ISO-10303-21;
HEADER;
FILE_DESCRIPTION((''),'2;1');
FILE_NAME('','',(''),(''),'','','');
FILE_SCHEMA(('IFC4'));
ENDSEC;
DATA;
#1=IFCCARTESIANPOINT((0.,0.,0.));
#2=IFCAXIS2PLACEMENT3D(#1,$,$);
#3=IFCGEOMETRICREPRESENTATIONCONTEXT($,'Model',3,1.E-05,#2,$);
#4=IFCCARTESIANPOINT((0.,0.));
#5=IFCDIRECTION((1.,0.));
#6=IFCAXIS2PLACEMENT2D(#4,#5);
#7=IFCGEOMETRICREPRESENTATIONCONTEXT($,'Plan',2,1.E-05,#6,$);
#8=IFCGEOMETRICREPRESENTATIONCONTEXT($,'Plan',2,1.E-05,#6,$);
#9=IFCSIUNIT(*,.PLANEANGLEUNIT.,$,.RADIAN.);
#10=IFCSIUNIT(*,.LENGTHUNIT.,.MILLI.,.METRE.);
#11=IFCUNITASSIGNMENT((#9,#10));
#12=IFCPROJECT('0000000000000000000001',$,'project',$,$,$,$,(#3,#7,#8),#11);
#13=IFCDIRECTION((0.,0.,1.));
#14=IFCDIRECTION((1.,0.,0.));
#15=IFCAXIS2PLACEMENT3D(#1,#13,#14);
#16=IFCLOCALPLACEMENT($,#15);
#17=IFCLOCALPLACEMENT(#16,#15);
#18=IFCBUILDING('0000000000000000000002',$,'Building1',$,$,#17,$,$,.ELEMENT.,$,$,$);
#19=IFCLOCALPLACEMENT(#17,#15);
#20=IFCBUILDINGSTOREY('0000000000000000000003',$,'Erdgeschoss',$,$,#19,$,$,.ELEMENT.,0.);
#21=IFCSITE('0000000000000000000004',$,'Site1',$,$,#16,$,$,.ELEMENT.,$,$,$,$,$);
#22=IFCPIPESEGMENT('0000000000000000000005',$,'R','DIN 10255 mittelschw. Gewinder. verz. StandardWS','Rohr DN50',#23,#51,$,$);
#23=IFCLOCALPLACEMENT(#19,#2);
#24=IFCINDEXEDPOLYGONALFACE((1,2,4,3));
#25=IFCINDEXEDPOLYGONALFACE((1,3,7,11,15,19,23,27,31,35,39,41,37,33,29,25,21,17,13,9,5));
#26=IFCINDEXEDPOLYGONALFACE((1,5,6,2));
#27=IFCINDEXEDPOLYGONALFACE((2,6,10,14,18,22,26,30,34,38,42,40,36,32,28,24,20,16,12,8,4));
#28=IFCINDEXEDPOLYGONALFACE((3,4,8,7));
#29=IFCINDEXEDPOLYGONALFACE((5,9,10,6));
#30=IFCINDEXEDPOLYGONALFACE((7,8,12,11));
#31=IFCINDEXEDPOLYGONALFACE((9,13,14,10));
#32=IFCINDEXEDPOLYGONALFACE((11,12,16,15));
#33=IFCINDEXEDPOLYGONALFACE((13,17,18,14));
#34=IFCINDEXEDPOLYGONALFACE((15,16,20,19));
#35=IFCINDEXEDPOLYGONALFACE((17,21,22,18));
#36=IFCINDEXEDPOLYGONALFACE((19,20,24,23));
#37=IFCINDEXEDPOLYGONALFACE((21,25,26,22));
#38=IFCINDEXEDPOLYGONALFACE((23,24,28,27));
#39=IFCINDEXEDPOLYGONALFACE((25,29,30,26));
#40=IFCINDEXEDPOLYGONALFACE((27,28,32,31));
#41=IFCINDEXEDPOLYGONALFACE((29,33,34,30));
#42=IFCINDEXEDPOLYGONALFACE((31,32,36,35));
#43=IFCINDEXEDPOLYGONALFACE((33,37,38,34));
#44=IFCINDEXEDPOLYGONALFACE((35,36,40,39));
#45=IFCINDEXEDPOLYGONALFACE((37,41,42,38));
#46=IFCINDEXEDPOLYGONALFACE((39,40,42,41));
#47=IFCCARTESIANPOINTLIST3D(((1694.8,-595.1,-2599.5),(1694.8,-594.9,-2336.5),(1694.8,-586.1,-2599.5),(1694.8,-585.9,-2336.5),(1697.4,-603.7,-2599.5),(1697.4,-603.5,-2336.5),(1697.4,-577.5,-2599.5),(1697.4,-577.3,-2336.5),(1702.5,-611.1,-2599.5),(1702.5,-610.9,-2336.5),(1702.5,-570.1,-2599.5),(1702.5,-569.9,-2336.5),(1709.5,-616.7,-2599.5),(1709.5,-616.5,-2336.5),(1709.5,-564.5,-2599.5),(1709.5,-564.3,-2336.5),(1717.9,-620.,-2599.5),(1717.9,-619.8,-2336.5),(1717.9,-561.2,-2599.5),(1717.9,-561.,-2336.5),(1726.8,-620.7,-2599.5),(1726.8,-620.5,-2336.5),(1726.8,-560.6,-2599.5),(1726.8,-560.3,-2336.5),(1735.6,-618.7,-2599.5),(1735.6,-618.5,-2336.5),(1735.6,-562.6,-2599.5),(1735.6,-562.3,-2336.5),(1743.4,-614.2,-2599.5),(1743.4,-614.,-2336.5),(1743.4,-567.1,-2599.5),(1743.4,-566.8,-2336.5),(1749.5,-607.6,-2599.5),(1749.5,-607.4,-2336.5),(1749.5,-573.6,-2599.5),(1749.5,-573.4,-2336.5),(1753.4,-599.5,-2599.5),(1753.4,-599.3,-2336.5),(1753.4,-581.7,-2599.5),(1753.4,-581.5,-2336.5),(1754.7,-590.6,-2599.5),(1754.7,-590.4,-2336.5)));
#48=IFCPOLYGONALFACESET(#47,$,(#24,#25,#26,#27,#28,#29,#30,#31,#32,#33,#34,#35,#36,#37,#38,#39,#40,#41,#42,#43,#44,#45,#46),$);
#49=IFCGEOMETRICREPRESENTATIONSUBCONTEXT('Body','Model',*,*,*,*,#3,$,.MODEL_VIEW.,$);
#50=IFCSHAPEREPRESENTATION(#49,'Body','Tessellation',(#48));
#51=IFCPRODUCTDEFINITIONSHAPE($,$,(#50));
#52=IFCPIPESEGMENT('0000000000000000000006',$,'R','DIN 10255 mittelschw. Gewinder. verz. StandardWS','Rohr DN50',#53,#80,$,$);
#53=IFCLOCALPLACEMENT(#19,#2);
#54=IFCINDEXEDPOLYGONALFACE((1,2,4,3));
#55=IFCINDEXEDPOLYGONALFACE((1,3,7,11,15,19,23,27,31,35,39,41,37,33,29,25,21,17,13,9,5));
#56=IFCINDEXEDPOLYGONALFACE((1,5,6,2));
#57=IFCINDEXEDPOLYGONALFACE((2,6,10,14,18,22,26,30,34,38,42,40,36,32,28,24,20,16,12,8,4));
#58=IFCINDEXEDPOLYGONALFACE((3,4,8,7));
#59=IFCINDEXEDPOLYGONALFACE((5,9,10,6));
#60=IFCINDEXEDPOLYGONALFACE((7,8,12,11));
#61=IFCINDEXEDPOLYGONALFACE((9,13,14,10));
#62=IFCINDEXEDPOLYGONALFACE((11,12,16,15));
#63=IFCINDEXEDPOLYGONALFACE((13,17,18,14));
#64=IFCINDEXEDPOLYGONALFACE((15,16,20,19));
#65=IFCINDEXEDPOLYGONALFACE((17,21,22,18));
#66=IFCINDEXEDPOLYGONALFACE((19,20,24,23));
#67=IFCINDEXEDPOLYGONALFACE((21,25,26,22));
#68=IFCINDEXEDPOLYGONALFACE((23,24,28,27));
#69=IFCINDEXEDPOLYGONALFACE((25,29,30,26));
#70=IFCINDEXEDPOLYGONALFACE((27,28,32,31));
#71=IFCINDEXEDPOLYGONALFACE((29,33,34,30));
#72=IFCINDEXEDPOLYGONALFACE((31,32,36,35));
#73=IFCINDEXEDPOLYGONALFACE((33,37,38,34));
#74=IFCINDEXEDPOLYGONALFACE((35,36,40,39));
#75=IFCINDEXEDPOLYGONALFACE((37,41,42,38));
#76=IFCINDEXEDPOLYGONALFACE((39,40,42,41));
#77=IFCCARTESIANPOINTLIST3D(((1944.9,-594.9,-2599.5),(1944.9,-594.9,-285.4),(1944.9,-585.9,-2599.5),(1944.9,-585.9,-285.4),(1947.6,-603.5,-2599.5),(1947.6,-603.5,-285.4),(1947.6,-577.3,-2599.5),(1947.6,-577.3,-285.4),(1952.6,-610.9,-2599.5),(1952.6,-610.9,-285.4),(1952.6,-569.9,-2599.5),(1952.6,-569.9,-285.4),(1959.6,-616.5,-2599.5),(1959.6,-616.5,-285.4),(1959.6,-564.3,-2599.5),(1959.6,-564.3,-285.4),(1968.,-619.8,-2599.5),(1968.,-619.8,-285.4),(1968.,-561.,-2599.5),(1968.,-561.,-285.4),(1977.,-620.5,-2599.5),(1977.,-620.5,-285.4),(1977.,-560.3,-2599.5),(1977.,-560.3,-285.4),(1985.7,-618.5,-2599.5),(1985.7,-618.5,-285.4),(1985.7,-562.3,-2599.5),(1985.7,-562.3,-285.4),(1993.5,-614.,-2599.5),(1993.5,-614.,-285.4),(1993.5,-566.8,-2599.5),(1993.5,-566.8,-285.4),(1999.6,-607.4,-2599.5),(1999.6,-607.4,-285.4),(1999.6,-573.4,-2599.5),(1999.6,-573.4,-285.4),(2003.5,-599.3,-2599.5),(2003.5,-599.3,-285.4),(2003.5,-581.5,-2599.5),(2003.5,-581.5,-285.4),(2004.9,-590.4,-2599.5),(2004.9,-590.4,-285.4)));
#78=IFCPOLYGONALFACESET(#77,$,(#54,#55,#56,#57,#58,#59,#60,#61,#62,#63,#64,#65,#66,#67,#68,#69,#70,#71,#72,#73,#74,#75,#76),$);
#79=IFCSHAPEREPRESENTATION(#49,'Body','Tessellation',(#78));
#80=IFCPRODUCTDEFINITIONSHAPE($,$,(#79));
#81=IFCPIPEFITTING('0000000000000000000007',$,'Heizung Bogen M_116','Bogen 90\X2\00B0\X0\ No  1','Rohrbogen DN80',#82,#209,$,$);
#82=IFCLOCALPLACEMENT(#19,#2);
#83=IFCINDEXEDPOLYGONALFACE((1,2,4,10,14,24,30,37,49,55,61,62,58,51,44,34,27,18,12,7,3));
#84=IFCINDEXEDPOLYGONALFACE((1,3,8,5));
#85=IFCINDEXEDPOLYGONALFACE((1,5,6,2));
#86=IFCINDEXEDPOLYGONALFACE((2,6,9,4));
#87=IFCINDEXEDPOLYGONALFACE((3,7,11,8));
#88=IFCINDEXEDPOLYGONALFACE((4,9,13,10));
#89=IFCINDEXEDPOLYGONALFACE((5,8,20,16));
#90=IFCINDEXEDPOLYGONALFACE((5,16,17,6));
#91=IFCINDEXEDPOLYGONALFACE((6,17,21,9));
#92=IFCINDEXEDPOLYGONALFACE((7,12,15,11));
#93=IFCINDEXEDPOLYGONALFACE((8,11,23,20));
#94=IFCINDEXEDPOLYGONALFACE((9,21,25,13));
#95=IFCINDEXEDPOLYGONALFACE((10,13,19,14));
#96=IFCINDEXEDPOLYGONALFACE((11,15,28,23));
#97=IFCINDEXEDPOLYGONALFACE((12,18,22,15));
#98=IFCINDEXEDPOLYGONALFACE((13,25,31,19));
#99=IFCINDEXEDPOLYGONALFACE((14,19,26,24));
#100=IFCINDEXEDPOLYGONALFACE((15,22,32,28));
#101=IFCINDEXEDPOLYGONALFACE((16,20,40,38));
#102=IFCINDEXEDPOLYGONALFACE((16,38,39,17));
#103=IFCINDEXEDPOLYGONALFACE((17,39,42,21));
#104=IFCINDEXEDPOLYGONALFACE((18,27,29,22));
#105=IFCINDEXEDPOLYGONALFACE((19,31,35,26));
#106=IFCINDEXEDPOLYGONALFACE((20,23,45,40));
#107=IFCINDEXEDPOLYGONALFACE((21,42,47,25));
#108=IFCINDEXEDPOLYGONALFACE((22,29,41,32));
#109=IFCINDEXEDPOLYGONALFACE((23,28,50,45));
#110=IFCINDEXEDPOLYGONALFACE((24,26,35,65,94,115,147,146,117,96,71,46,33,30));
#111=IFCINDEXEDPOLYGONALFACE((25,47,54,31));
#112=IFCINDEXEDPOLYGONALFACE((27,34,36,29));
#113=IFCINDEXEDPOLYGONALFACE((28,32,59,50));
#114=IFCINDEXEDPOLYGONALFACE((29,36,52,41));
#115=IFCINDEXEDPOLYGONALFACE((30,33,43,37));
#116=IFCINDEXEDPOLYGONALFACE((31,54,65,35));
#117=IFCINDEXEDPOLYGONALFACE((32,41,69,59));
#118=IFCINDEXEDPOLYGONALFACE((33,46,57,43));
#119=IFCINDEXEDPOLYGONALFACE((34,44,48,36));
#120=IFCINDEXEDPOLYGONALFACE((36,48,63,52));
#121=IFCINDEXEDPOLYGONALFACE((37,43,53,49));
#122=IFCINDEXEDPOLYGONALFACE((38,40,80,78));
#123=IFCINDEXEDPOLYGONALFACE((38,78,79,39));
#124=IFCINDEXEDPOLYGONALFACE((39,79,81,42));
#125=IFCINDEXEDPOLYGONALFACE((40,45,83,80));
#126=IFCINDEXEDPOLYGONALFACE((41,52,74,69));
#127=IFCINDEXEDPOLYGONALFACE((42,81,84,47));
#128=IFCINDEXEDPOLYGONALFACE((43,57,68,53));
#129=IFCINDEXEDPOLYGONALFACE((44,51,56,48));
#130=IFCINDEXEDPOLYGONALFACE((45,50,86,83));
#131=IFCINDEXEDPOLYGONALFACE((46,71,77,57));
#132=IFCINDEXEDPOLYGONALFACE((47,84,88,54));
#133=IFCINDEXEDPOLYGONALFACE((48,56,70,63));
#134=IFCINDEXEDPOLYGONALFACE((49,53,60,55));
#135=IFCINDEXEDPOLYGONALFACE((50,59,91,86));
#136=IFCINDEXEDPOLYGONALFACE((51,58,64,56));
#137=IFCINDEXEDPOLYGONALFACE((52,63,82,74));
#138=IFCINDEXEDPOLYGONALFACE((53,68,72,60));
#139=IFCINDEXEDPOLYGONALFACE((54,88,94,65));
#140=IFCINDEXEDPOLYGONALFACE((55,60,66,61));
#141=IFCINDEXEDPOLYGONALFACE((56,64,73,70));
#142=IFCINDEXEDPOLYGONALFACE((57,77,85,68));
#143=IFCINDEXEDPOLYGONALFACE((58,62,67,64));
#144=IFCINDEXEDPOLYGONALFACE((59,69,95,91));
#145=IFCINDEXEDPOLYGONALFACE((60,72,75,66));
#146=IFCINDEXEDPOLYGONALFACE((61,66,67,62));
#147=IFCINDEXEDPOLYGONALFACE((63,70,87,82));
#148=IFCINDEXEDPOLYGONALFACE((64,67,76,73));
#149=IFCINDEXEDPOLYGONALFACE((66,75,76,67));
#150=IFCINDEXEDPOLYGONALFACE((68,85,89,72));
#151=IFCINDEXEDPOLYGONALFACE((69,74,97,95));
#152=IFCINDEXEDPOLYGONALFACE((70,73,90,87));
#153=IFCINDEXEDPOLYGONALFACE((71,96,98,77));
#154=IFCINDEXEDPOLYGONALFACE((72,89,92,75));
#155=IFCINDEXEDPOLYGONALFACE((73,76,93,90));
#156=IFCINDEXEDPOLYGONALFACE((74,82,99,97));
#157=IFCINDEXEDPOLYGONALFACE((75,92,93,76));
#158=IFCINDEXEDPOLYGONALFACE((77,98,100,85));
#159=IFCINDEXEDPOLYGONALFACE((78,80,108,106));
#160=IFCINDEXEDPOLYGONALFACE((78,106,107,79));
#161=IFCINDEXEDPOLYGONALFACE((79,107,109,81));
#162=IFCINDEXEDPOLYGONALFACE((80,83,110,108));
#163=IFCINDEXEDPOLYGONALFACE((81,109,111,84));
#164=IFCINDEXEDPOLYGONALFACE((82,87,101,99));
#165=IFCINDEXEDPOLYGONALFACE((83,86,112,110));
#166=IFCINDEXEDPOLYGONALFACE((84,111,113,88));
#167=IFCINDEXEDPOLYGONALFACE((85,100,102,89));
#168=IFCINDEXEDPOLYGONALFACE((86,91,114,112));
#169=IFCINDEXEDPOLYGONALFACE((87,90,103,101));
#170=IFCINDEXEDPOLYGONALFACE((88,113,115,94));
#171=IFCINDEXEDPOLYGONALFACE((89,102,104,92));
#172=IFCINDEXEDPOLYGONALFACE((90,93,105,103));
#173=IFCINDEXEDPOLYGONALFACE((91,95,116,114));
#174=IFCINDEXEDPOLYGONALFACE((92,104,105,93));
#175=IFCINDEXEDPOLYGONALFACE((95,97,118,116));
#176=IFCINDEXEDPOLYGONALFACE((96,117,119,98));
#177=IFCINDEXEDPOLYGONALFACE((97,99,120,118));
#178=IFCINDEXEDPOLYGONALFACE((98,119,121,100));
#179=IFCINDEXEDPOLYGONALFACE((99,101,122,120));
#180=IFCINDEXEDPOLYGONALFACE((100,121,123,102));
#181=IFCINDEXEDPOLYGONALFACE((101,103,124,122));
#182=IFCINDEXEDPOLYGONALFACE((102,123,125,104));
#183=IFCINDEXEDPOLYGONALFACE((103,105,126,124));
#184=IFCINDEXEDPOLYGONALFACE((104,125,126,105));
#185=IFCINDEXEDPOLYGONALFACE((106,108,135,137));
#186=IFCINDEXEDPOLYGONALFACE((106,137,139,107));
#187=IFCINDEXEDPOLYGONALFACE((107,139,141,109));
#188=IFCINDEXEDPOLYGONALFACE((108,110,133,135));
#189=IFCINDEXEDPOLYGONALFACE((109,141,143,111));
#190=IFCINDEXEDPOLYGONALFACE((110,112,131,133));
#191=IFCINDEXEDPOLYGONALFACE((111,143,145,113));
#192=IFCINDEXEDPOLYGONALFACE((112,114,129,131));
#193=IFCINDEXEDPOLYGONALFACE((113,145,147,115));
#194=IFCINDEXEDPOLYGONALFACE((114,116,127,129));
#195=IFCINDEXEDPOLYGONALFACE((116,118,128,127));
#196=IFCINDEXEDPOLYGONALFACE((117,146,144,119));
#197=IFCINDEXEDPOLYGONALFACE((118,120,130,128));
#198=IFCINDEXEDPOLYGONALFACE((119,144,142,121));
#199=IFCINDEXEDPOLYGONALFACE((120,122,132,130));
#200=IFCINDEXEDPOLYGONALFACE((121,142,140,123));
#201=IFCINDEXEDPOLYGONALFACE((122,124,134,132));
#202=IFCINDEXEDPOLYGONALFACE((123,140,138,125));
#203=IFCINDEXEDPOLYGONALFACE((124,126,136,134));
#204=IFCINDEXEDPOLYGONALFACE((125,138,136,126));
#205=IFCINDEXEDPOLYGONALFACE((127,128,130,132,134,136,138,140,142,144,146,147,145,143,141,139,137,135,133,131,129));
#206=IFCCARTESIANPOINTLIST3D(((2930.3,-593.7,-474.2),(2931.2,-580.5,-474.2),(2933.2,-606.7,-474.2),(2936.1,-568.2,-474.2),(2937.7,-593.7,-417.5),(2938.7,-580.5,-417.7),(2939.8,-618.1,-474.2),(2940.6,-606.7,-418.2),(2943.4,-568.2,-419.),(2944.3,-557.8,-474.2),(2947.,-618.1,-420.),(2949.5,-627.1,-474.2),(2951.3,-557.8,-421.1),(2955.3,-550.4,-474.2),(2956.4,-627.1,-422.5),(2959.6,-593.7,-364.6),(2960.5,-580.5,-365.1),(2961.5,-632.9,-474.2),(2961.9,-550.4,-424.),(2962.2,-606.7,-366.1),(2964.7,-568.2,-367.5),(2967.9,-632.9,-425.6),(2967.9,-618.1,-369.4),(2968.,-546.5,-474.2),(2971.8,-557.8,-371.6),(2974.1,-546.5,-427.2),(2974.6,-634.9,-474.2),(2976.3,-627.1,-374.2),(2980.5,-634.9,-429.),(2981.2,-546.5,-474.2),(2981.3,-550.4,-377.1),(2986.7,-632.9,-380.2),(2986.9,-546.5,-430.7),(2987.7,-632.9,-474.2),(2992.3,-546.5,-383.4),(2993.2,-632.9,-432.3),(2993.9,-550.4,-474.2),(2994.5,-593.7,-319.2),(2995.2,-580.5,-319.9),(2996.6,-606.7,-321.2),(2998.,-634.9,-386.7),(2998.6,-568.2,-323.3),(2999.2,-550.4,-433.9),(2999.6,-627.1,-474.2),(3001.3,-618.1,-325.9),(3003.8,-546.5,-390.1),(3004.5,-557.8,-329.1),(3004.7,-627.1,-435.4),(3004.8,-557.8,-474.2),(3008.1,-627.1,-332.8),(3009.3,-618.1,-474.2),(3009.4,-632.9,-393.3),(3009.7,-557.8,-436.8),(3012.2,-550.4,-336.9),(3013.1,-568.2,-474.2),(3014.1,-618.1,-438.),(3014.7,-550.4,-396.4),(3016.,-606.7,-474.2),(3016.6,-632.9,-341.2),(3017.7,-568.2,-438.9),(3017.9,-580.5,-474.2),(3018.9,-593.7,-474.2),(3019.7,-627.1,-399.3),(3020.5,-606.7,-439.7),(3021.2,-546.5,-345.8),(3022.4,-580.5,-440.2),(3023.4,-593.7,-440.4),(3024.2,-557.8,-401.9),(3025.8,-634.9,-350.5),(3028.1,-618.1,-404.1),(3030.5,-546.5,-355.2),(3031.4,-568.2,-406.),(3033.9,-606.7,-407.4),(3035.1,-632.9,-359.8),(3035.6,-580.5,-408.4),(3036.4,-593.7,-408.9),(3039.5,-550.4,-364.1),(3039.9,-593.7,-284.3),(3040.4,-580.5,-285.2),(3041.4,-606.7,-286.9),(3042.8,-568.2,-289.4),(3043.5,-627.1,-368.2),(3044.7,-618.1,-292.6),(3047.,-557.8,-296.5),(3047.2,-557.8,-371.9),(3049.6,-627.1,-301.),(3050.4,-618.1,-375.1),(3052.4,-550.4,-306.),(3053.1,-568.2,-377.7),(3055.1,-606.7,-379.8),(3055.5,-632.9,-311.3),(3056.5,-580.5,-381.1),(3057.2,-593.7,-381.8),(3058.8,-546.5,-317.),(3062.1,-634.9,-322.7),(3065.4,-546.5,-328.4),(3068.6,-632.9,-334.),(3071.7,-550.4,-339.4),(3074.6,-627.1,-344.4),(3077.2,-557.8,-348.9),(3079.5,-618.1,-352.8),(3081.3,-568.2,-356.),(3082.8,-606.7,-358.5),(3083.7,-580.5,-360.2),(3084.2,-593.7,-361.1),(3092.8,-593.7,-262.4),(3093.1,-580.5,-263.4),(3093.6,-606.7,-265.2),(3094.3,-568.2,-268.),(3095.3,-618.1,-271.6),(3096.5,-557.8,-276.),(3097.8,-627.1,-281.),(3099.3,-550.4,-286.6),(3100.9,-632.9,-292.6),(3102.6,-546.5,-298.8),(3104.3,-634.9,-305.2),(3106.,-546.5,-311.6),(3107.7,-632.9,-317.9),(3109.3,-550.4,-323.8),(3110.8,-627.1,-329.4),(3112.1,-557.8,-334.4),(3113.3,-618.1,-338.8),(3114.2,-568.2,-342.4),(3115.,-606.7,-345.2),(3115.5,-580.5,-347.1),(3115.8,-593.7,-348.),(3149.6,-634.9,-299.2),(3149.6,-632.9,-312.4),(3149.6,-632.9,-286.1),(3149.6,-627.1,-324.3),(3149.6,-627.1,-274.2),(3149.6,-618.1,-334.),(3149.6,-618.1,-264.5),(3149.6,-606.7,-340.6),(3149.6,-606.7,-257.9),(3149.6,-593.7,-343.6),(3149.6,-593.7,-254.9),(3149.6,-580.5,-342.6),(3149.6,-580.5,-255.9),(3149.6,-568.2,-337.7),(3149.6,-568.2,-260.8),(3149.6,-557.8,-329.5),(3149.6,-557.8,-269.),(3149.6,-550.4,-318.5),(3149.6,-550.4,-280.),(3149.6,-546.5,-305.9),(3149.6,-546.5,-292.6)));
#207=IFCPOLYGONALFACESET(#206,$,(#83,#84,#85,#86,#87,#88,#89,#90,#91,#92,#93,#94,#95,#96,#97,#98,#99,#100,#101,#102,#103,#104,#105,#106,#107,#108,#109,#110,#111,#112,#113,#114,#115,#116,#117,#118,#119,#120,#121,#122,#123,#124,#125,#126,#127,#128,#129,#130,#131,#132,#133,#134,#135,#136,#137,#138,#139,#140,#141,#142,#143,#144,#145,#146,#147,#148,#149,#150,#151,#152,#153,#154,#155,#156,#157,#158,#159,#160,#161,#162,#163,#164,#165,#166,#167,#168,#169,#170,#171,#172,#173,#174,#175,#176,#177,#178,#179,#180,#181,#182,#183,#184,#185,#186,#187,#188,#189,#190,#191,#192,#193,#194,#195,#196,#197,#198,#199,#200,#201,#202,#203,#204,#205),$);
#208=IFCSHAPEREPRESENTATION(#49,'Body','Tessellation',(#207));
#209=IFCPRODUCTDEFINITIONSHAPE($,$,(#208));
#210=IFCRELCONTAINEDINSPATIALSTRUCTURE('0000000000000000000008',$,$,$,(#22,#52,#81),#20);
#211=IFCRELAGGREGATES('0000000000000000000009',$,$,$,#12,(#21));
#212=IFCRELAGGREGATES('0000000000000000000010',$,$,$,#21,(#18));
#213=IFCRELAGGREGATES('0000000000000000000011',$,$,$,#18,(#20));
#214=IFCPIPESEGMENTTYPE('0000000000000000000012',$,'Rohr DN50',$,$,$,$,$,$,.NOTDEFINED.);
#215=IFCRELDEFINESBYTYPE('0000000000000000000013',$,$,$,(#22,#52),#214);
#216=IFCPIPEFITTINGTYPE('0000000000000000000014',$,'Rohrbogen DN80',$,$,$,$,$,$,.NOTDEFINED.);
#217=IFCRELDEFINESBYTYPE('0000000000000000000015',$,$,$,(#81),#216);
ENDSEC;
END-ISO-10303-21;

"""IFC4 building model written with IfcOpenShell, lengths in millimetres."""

from ifc_helpers import new_model, entity, si_unit, frame, origin, origin_with_axes, origin_2d_with_axis, place, context, subcontext, project, spatial, circle, extrude, shape, source, transform, mapped, type_object, element, save


model = new_model("IFC4")

# Units and contexts
model_context = context("Model", 3, precision=1e-05, world=origin())
plan_context_1 = context("Plan", 2, precision=1e-05, world=origin_2d_with_axis())
plan_context_2 = context("Plan", 2, precision=1e-05, world=origin_2d_with_axis())
body_context = subcontext(model_context, "Body", "Model", "MODEL_VIEW")
ifc_project = project(units=[si_unit("PLANEANGLEUNIT", "RADIAN"), si_unit("LENGTHUNIT", "METRE", prefix="MILLI")], contexts=[model_context, plan_context_1, plan_context_2])

# Site, building, storey
site_placement = place(None, origin_with_axes())
site = spatial("IfcSite", under=ifc_project, at=site_placement, Name="Site1", CompositionType="ELEMENT")
building_placement = place(site_placement, origin_with_axes())
building = spatial("IfcBuilding", under=site, at=building_placement, Name="Building1", CompositionType="ELEMENT")
storey_placement = place(building_placement, origin_with_axes())
storey = spatial("IfcBuildingStorey", under=building, at=storey_placement, Name="Erdgeschoss", CompositionType="ELEMENT", Elevation=0.0)

# Pipe segments
pipe_segment_type_1 = type_object("IfcPipeSegmentType", Name="Rohr DN50", PredefinedType="NOTDEFINED")
pipe_segment_1_placement = place(storey_placement, frame((1724.6, -590.7, -2468.0), z_axis=(0.0, 0.0, 1.0), x_axis=(1.0, 0.0, 0.0)))
element("IfcPipeSegment", 1, at=pipe_segment_1_placement, inside=storey, type_object=pipe_segment_type_1, Name="R", Description="DIN 10255 mittelschw. Gewinder. verz. StandardWS", ObjectType="Rohr DN50", context=body_context, shape_type="SolidModel", body=[
    extrude(circle(Radius=30.1, at=origin_2d_with_axis()), frame((0.0, 0.0, -131.5), z_axis=(0.0, 0.000808, 1.0), x_axis=(1.0, 0.0, 0.0)), (0.0, 0.0, 1.0), 263.0),
])
pipe_segment_2_placement = place(storey_placement, frame((1974.7, -590.6, -1442.4), z_axis=(0.0, 0.0, 1.0), x_axis=(1.0, 0.0, 0.0)))
element("IfcPipeSegment", 2, at=pipe_segment_2_placement, inside=storey, type_object=pipe_segment_type_1, Name="R", Description="DIN 10255 mittelschw. Gewinder. verz. StandardWS", ObjectType="Rohr DN50", context=body_context, shape_type="SolidModel", body=[
    extrude(circle(Radius=30.1, at=origin_2d_with_axis()), frame((0.0, 0.1, -1157.1), z_axis=(0.0, 0.0, 1.0), x_axis=(1.0, 0.0, 0.0)), (0.0, 0.0, 1.0), 2314.1),
])

# Pipe fitting
pipe_fitting_type_1 = type_object("IfcPipeFittingType", Name="Rohrbogen DN80", PredefinedType="NOTDEFINED")
shared_shape_1 = source(origin_with_axes(), body_context, "Body", "SolidModel", [
    entity("IfcRevolvedAreaSolid", entity("IfcCircleProfileDef", "AREA", None, entity("IfcAxis2Placement2D", entity("IfcCartesianPoint", [0.0, 0.0]), entity("IfcDirection", [1.0, 0.0])), 44.5), entity("IfcAxis2Placement3D", entity("IfcCartesianPoint", [109.7, -65.3, 0.0]), entity("IfcDirection", [-1.0, 0.0, 0.0]), entity("IfcDirection", [0.0, 0.0, 1.0])), entity("IfcAxis1Placement", entity("IfcCartesianPoint", [0.0, 175.0, 0.0]), entity("IfcDirection", [-1.0, 0.0, 0.0])), 1.570796),
])
pipe_fitting_1_placement = place(storey_placement, frame((3039.9, -590.4, -364.5), z_axis=(0.0, 0.0, 1.0), x_axis=(1.0, 0.0, 0.0)))
element("IfcPipeFitting", 3, at=pipe_fitting_1_placement, inside=storey, type_object=pipe_fitting_type_1, Name="Heizung Bogen M_116", Description="Bogen 90° No  1", ObjectType="Rohrbogen DN80", shapes=[
    shape(body_context, "Body", "MappedRepresentation", [mapped(shared_shape_1, transform((0.0, 0.0, 0.0), x_axis=(0.0, 0.0, -1.0), y_axis=(1.0, 0.0, 0.0), z_axis=(0.0, -1.0, 0.0), scale=1.0))]),
    shape(body_context, "Body", "MappedRepresentation", [mapped(shared_shape_1, transform((0.0, 0.0, 0.0), x_axis=(0.0, 0.0, -1.0), y_axis=(1.0, 0.0, 0.0), z_axis=(0.0, -1.0, 0.0), scale=1.0))]),
])

save(model, "model.ifc")
